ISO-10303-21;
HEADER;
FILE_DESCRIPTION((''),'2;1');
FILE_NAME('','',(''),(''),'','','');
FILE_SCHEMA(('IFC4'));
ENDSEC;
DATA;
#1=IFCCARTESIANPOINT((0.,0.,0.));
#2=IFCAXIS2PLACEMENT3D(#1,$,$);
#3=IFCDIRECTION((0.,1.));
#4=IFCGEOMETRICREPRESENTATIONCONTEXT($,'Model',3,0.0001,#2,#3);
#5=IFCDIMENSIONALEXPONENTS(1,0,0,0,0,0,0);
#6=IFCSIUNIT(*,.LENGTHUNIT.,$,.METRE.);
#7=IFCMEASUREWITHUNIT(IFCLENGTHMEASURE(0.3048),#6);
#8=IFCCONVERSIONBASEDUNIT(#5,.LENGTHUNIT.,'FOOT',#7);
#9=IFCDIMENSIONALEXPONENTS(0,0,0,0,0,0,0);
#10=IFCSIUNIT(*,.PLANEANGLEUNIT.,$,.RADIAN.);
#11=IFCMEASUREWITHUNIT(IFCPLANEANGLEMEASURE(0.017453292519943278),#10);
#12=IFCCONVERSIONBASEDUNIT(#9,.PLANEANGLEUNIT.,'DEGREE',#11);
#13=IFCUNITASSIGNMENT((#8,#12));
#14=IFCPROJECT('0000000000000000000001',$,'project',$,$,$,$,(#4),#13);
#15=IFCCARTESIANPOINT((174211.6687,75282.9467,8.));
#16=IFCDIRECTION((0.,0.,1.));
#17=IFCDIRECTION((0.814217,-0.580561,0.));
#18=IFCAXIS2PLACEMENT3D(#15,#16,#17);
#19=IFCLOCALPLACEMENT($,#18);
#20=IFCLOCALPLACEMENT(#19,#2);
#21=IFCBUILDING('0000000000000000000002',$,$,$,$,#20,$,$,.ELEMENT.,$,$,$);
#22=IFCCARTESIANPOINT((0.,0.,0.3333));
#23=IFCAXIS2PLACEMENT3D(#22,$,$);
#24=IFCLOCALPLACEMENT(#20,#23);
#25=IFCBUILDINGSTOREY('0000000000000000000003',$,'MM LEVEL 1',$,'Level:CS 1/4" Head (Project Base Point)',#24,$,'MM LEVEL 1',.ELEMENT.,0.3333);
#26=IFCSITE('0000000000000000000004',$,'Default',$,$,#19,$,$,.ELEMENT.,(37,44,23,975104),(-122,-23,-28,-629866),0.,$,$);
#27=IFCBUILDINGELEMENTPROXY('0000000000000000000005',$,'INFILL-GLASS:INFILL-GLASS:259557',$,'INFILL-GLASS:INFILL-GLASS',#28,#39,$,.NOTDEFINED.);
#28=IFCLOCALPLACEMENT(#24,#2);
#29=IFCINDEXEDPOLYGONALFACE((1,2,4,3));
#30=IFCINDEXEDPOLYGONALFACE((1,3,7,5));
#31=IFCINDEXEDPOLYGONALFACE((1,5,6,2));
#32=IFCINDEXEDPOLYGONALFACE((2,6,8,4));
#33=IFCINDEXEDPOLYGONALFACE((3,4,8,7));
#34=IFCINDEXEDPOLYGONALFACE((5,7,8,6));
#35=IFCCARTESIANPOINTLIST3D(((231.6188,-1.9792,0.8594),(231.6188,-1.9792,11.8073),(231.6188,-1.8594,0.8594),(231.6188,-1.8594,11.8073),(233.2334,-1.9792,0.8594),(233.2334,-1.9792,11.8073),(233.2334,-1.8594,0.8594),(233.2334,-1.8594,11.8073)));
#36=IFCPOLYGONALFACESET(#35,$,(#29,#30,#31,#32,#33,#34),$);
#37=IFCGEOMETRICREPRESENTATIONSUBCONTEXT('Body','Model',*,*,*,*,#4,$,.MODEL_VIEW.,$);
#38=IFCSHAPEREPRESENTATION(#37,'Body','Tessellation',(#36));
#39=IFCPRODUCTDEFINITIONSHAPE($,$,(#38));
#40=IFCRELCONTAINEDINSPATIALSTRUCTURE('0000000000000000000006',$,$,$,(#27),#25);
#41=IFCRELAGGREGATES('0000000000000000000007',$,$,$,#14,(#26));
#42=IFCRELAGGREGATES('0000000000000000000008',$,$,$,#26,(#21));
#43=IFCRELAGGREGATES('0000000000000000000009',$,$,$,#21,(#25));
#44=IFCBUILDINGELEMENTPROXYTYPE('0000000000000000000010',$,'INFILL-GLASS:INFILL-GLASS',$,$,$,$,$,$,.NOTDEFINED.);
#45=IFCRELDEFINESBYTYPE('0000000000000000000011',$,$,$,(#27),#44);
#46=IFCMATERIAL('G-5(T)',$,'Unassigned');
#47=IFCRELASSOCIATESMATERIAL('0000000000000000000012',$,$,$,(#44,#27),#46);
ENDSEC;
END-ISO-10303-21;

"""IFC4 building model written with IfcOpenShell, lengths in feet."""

from ifc_helpers import new_model, entity, si_unit, converted_unit, direction, frame, origin, place, context, subcontext, project, spatial, indexed_curve, outline, extrude, source, transform, mapped, material, type_object, type_shapes, element, save


model = new_model("IFC4")

# Units and contexts
model_context = context("Model", 3, precision=0.0001, world=origin(), true_north=direction((0.0, 1.0)))
body_context = subcontext(model_context, "Body", "Model", "MODEL_VIEW")
ifc_project = project(units=[converted_unit("LENGTHUNIT", "FOOT", entity("IfcLengthMeasure", 0.3048), si_unit("LENGTHUNIT", "METRE"), dimensions=[1, 0, 0, 0, 0, 0, 0]), converted_unit("PLANEANGLEUNIT", "DEGREE", entity("IfcPlaneAngleMeasure", 0.017453292519943278), si_unit("PLANEANGLEUNIT", "RADIAN"), dimensions=[0, 0, 0, 0, 0, 0, 0])], contexts=[model_context])

# Site, building, storey
site_placement = place(None, frame((174211.6687, 75282.9467, 8.0), z_axis=(0.0, 0.0, 1.0), x_axis=(0.814217, -0.580561, 0.0)))
site = spatial("IfcSite", under=ifc_project, at=site_placement, Name="Default", CompositionType="ELEMENT", RefLatitude=(37, 44, 23, 975104), RefLongitude=(-122, -23, -28, -629866), RefElevation=0.0)
building_placement = place(site_placement, origin())
building = spatial("IfcBuilding", under=site, at=building_placement, CompositionType="ELEMENT")
storey_placement = place(building_placement, frame((0.0, 0.0, 0.3333)))
storey = spatial("IfcBuildingStorey", under=building, at=storey_placement, Name="MM LEVEL 1", ObjectType="Level:CS 1/4\" Head (Project Base Point)", LongName="MM LEVEL 1", CompositionType="ELEMENT", Elevation=0.3333)

# Building element proxy
ifc_material_1 = material(Name="G-5(T)", Category="Unassigned")
building_element_proxy_type_1 = type_object("IfcBuildingElementProxyType", Name="INFILL-GLASS:INFILL-GLASS", PredefinedType="NOTDEFINED", material=ifc_material_1)
shared_shape_1 = source(origin(), body_context, "Body", "SweptSolid", [
    extrude(outline(indexed_curve([(-0.0599, -0.8073), (0.0599, -0.8073), (0.0599, 0.8073), (-0.0599, 0.8073), (-0.0599, -0.8073)], self_intersect=False)), frame((0.0, 0.1016, 0.1302), z_axis=(0.0, 0.0, 1.0), x_axis=(0.0, 1.0, 0.0)), (0.0, 0.0, 1.0), 10.9479),
])
type_shapes(building_element_proxy_type_1, [shared_shape_1])
proxy_1_placement = place(storey_placement, frame((232.4261, -2.0208, 0.7292)))
element("IfcBuildingElementProxy", 1, at=proxy_1_placement, inside=storey, type_object=building_element_proxy_type_1, material=ifc_material_1, Name="INFILL-GLASS:INFILL-GLASS:259557", ObjectType="INFILL-GLASS:INFILL-GLASS", PredefinedType="NOTDEFINED", context=body_context, shape_type="MappedRepresentation", body=[
    mapped(shared_shape_1, transform((0.0, 0.0, 0.0), scale=1.0)),
])

save(model, "model.ifc")
